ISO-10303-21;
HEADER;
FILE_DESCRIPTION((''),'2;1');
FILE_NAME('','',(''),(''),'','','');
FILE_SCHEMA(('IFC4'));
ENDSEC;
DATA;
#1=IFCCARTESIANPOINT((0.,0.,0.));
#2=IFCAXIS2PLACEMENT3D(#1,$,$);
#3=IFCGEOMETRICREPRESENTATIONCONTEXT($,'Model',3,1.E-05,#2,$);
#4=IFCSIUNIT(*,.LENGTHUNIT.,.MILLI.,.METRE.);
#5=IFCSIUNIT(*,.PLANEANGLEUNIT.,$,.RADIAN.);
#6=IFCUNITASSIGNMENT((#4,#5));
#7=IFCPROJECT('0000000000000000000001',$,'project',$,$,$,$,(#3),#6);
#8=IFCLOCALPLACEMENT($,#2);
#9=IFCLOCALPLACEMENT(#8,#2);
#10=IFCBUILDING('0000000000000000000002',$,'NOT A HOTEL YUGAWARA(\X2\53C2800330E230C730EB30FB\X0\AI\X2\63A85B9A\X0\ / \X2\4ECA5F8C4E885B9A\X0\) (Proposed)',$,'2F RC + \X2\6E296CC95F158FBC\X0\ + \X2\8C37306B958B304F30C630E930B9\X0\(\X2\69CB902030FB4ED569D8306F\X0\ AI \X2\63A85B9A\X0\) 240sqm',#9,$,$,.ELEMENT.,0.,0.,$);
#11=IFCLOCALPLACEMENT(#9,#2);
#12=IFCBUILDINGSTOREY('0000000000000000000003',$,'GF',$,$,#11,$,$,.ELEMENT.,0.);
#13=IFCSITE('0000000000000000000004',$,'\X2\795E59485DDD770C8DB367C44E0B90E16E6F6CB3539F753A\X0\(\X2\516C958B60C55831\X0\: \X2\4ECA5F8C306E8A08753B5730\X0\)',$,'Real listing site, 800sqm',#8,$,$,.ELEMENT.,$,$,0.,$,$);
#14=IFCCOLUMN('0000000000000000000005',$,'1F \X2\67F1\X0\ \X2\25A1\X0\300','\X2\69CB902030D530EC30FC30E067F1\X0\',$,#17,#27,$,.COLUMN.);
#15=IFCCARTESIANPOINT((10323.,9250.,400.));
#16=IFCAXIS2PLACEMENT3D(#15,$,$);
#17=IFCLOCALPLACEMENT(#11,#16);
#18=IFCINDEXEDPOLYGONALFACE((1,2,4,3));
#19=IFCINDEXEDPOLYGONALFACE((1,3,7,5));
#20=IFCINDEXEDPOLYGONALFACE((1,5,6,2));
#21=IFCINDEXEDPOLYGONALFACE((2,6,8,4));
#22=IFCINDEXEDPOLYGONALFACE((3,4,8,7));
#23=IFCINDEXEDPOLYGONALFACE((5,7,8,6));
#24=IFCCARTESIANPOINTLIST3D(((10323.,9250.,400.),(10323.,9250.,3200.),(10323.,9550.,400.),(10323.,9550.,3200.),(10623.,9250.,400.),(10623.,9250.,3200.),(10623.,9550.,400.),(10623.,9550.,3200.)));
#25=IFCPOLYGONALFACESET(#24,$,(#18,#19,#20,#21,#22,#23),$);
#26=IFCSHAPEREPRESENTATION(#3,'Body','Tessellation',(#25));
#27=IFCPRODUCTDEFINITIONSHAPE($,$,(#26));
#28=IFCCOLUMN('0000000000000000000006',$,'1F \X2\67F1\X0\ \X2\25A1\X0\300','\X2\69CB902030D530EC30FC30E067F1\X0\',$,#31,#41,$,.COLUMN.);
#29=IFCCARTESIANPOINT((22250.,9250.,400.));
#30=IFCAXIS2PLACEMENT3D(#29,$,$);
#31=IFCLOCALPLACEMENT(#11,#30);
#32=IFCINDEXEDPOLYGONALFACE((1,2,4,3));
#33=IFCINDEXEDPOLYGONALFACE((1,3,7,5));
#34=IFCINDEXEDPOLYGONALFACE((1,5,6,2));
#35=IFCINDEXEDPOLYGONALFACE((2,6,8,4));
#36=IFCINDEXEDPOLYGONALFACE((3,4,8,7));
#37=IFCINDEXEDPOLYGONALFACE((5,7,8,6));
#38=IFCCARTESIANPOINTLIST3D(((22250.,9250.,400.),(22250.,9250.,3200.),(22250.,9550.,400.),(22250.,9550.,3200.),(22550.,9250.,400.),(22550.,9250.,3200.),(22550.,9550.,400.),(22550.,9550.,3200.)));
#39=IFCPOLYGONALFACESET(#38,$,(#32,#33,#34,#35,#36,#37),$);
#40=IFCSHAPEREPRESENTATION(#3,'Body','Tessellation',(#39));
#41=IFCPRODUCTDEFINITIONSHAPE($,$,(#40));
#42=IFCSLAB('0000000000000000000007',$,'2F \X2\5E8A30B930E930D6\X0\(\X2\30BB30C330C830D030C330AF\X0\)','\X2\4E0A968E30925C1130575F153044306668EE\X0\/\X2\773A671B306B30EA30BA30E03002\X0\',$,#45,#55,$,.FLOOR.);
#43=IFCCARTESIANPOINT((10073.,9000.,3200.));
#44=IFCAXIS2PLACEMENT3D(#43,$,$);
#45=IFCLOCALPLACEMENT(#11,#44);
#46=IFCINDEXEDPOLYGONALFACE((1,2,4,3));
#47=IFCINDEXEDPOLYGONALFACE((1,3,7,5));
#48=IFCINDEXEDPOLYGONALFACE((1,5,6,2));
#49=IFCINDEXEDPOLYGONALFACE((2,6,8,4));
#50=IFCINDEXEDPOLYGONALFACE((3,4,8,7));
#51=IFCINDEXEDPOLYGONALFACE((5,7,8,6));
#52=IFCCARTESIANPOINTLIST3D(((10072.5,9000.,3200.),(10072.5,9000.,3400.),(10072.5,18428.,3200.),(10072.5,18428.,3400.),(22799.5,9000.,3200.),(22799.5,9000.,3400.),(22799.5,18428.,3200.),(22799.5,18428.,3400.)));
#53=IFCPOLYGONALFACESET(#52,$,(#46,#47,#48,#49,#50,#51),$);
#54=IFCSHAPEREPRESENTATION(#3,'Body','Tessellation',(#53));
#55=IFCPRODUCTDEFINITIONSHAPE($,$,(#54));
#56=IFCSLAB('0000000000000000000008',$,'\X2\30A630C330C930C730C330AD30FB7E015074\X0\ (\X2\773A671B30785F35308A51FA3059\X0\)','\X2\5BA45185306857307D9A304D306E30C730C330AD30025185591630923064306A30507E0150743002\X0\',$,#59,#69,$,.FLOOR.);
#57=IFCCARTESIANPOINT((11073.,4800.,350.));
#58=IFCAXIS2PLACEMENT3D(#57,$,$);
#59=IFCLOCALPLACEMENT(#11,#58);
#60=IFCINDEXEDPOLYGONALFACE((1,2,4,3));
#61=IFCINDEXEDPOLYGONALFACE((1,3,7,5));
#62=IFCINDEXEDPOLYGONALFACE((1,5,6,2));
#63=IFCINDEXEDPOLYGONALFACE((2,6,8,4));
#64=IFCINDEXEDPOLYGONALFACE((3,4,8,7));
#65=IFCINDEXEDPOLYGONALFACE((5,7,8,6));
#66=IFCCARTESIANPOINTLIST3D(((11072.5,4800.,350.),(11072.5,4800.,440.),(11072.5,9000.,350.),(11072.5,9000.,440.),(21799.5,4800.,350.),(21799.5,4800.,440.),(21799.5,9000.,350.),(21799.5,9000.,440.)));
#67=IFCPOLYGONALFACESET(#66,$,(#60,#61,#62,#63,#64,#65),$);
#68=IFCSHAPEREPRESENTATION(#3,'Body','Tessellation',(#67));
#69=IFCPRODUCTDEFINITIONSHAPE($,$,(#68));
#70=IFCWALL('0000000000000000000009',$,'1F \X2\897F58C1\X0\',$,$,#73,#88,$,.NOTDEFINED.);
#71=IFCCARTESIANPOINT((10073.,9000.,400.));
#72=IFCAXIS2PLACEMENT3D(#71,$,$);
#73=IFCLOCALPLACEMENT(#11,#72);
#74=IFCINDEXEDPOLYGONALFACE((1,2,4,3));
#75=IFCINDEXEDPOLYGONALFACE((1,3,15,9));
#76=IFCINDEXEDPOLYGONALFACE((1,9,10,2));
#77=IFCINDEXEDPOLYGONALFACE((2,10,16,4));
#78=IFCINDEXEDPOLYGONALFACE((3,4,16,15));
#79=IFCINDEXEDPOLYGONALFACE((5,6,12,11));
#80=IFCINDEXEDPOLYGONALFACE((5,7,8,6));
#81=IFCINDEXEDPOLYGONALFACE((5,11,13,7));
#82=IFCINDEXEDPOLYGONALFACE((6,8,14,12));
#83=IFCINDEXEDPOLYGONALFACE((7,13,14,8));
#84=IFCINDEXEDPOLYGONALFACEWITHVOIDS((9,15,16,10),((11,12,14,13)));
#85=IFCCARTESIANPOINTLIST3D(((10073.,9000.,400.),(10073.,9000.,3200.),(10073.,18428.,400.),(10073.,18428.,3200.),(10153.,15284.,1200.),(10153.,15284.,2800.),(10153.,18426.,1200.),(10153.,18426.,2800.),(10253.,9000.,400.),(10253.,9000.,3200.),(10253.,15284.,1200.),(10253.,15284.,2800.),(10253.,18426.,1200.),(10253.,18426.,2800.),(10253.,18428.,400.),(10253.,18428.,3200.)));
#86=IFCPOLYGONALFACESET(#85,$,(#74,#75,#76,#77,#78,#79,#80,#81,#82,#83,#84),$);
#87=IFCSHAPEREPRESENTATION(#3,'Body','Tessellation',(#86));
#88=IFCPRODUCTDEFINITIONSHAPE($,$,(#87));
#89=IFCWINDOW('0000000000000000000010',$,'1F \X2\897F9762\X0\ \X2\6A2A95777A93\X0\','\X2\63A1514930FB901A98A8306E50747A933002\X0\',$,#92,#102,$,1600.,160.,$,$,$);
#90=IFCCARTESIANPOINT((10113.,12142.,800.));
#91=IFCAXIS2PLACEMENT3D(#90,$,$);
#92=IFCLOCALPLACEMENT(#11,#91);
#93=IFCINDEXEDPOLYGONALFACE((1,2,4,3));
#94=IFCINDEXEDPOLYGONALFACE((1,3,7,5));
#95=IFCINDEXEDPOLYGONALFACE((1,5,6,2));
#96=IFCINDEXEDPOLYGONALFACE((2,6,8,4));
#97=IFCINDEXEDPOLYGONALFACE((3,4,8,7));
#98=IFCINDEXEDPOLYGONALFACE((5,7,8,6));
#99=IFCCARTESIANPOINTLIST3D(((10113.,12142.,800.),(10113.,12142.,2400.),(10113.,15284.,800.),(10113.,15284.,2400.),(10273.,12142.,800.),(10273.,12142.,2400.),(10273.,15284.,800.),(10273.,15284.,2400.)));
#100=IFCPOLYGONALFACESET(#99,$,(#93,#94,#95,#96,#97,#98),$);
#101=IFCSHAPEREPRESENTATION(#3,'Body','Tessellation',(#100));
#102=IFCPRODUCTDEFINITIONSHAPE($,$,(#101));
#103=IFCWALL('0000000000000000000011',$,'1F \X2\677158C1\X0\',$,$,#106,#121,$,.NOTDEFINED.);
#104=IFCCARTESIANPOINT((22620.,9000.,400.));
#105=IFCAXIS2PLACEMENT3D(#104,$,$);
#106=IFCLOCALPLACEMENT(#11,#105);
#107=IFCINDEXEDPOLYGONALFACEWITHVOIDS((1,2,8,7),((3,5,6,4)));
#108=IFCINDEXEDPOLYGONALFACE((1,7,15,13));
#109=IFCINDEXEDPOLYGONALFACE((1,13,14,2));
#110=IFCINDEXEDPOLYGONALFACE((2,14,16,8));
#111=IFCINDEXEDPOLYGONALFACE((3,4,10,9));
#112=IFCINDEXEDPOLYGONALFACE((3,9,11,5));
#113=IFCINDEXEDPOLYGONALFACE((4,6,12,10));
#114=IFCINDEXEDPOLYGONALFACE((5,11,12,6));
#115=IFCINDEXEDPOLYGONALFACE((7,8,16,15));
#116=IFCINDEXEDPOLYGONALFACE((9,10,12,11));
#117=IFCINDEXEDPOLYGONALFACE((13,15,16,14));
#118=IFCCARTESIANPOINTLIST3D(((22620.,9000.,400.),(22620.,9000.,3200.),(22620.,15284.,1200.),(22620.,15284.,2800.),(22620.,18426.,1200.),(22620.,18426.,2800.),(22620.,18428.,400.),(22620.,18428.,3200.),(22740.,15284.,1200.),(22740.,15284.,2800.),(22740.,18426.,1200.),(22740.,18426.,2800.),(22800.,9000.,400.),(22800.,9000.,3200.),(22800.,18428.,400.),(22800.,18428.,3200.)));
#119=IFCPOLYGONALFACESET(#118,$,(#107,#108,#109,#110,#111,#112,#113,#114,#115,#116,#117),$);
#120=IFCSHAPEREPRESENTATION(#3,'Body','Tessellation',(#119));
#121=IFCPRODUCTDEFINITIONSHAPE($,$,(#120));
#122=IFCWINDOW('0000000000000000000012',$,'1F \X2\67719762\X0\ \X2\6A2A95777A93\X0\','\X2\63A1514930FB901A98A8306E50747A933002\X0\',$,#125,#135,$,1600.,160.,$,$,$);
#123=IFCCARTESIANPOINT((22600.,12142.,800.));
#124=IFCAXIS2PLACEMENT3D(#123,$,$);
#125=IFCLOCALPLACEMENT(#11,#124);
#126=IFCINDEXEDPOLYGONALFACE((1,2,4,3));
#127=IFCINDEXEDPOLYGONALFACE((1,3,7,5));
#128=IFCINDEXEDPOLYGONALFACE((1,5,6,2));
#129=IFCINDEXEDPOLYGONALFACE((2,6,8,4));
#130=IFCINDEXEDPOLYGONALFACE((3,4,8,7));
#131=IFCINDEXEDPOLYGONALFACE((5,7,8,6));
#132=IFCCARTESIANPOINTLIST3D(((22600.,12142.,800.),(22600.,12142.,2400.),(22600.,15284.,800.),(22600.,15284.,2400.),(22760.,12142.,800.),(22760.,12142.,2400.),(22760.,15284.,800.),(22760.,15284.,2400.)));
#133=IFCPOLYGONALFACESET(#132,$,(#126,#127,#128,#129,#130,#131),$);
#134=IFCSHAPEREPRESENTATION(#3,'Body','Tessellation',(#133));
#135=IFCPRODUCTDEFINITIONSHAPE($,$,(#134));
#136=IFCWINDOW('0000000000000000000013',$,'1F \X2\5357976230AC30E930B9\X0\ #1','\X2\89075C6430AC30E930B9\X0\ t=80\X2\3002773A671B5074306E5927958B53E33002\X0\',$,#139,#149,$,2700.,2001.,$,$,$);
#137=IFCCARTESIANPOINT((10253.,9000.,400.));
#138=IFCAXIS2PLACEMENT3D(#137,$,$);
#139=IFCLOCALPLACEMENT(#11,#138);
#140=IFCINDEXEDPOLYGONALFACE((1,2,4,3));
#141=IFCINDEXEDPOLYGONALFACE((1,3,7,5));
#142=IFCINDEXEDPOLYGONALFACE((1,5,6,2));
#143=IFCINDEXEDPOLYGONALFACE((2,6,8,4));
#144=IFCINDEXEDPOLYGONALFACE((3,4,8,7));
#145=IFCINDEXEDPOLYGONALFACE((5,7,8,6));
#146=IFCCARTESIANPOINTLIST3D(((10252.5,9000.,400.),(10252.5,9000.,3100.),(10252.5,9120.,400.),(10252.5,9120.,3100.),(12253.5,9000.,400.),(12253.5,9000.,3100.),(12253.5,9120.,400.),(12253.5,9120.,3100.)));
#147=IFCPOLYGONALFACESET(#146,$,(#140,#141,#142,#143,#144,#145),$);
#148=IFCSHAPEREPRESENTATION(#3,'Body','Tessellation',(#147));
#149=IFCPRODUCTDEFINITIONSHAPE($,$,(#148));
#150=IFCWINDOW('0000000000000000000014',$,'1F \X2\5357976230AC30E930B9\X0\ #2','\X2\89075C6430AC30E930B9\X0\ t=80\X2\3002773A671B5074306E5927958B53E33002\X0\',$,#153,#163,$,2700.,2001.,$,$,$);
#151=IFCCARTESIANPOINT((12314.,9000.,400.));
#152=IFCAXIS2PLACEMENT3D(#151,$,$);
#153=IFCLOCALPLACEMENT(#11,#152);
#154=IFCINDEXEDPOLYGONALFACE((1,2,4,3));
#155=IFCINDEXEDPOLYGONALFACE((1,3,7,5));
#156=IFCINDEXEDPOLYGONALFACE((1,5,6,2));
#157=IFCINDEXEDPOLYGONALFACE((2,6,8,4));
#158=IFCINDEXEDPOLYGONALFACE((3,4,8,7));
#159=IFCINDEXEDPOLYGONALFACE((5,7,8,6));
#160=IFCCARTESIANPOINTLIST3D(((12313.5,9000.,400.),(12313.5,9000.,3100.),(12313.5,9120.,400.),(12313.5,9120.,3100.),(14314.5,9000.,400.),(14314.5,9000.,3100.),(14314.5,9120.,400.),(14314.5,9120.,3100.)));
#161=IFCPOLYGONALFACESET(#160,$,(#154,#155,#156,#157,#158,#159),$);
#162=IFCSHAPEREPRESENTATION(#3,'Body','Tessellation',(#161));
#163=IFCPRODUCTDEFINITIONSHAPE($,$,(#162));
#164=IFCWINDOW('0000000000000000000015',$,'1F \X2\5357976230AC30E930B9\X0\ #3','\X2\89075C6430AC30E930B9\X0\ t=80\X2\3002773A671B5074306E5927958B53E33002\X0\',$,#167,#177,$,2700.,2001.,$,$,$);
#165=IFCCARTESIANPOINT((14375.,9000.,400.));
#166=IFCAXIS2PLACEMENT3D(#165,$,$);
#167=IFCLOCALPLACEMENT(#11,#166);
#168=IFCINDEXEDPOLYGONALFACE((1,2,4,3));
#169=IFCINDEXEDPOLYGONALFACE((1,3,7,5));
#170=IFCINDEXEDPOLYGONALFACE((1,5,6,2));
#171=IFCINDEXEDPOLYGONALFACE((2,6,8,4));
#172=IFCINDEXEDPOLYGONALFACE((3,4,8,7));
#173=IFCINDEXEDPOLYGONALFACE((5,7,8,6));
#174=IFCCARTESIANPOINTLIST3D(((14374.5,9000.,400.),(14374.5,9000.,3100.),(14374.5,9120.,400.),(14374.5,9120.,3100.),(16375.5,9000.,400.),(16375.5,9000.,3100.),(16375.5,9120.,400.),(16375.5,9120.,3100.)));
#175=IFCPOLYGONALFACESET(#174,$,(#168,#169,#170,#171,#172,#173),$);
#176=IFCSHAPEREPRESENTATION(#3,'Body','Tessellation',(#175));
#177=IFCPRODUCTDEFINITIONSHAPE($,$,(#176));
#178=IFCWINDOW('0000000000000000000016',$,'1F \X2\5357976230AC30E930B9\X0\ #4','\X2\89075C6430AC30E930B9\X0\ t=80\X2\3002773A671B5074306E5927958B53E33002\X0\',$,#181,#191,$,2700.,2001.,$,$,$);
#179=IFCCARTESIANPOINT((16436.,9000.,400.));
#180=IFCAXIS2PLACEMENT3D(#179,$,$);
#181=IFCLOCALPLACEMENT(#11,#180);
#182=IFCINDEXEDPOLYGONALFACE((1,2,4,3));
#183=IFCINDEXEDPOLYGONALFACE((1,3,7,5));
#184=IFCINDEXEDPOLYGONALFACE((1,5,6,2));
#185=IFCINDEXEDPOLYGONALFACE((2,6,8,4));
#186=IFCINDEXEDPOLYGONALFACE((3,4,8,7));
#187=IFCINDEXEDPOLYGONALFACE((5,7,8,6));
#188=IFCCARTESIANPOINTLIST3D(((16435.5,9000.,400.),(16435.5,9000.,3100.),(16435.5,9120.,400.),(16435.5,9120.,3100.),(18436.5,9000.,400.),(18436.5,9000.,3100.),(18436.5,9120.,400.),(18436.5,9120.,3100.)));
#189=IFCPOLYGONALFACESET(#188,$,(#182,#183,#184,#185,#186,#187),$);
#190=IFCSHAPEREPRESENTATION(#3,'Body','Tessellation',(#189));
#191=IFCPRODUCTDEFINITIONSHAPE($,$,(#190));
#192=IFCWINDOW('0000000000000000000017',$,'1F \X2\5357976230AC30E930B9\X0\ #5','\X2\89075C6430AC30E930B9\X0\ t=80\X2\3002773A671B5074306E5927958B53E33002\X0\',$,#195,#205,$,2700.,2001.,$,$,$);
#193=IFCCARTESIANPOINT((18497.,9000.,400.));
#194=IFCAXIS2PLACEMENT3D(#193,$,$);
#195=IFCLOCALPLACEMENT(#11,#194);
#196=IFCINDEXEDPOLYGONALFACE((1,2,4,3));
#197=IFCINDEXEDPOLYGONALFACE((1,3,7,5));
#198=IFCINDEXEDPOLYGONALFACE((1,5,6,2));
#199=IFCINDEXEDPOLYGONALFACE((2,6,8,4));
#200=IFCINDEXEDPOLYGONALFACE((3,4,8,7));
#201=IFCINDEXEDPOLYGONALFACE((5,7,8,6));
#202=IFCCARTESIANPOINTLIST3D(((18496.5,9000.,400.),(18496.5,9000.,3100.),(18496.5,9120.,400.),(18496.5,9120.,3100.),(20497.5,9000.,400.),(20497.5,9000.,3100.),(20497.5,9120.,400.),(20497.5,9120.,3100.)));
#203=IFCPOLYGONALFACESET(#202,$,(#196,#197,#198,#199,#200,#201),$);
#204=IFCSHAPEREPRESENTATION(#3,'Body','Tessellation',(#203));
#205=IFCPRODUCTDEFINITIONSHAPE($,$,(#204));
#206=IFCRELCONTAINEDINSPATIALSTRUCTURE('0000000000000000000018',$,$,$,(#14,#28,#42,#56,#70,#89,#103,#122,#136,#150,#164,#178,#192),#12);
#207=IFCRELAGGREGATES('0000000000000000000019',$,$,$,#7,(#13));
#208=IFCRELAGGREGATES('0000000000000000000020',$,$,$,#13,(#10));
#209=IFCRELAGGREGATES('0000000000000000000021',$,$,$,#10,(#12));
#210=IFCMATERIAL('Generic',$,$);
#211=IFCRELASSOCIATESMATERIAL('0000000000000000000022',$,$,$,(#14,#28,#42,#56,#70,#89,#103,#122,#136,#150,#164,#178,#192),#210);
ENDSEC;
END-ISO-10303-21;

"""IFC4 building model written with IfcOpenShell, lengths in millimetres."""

from ifc_helpers import new_model, si_unit, frame, frame_2d, origin, place, context, project, spatial, rectangle, extrude, material, element, fill, save


model = new_model("IFC4")

# Units and contexts
model_context = context("Model", 3, precision=1e-05, world=origin())
ifc_project = project(units=[si_unit("LENGTHUNIT", "METRE", prefix="MILLI"), si_unit("PLANEANGLEUNIT", "RADIAN")], contexts=[model_context])

# Site, building, storey
site_placement = place(None, origin())
site = spatial("IfcSite", under=ifc_project, at=site_placement, Name="神奈川県足柄下郡湯河原町(公開情報: 今後の計画地)", ObjectType="Real listing site, 800sqm", CompositionType="ELEMENT", RefElevation=0.0)
building_placement = place(site_placement, origin())
building = spatial("IfcBuilding", under=site, at=building_placement, Name="NOT A HOTEL YUGAWARA(参考モデル・AI推定 / 今後予定) (Proposed)", ObjectType="2F RC + 温泉引込 + 谷に開くテラス(構造・仕様は AI 推定) 240sqm", CompositionType="ELEMENT", ElevationOfRefHeight=0.0, ElevationOfTerrain=0.0)
storey_placement = place(building_placement, origin())
storey = spatial("IfcBuildingStorey", under=building, at=storey_placement, Name="GF", CompositionType="ELEMENT", Elevation=0.0)

# Columns
ifc_material_1 = material(Name="Generic")
column_1_placement = place(storey_placement, frame((10323.0, 9250.0, 400.0)))
element("IfcColumn", 1, at=column_1_placement, inside=storey, material=ifc_material_1, Name="1F 柱 □300", Description="構造フレーム柱", PredefinedType="COLUMN", context=model_context, shape_type="SweptSolid", body=[
    extrude(rectangle(XDim=300.0, YDim=300.0, at=frame_2d((150.0, 150.0))), frame((10323.0, 9250.0, 400.0)), (0.0, 0.0, 1.0), 2800.0),
])
column_2_placement = place(storey_placement, frame((22250.0, 9250.0, 400.0)))
element("IfcColumn", 2, at=column_2_placement, inside=storey, material=ifc_material_1, Name="1F 柱 □300", Description="構造フレーム柱", PredefinedType="COLUMN", context=model_context, shape_type="SweptSolid", body=[
    extrude(rectangle(XDim=300.0, YDim=300.0, at=frame_2d((150.0, 150.0))), frame((22250.0, 9250.0, 400.0)), (0.0, 0.0, 1.0), 2800.0),
])

# Slabs
slab_1_placement = place(storey_placement, frame((10073.0, 9000.0, 3200.0)))
element("IfcSlab", 3, at=slab_1_placement, inside=storey, material=ifc_material_1, Name="2F 床スラブ(セットバック)", Description="上階を少し引いて森/眺望にリズム。", PredefinedType="FLOOR", context=model_context, shape_type="SweptSolid", body=[
    extrude(rectangle(XDim=12727.0, YDim=9428.0, at=frame_2d((6363.0, 4714.0))), frame((10073.0, 9000.0, 3200.0)), (0.0, 0.0, 1.0), 200.0),
])
slab_2_placement = place(storey_placement, frame((11073.0, 4800.0, 350.0)))
element("IfcSlab", 4, at=slab_2_placement, inside=storey, material=ifc_material_1, Name="ウッドデッキ・縁側 (眺望へ張り出す)", Description="室内と地続きのデッキ。内外をつなぐ縁側。", PredefinedType="FLOOR", context=model_context, shape_type="SweptSolid", body=[
    extrude(rectangle(XDim=10727.0, YDim=4200.0, at=frame_2d((5363.0, 2100.0))), frame((11073.0, 4800.0, 350.0)), (0.0, 0.0, 1.0), 90.0),
])

# Walls, openings, windows
wall_1_placement = place(storey_placement, frame((10073.0, 9000.0, 400.0)))
wall_1 = element("IfcWall", 5, at=wall_1_placement, inside=storey, material=ifc_material_1, Name="1F 西壁", PredefinedType="NOTDEFINED", context=model_context, shape_type="SweptSolid", body=[
    extrude(rectangle(XDim=180.0, YDim=9428.0, at=frame_2d((90.0, 4714.0))), frame((10073.0, 9000.0, 400.0)), (0.0, 0.0, 1.0), 2800.0),
])
opening_1_placement = place(storey_placement, frame((10113.0, 12142.0, 800.0)))
opening_1 = element("IfcOpeningElement", 6, at=opening_1_placement, cuts=wall_1, PredefinedType="NOTDEFINED", context=model_context, shape_type="SweptSolid", body=[
    extrude(rectangle(XDim=160.0, YDim=3142.0, at=frame_2d((80.0, 1571.0))), frame((10113.0, 12142.0, 800.0)), (0.0, 0.0, 1.0), 1600.0),
])
window_1_placement = place(storey_placement, frame((10113.0, 12142.0, 800.0)))
window_1 = element("IfcWindow", 7, at=window_1_placement, inside=storey, material=ifc_material_1, Name="1F 西面 横長窓", Description="採光・通風の側窓。", OverallHeight=1600.0, OverallWidth=160.0, context=model_context, shape_type="SweptSolid", body=[
    extrude(rectangle(XDim=160.0, YDim=3142.0, at=frame_2d((80.0, 1571.0))), frame((10113.0, 12142.0, 800.0)), (0.0, 0.0, 1.0), 1600.0),
])
fill(opening_1, window_1)
wall_2_placement = place(storey_placement, frame((22620.0, 9000.0, 400.0)))
wall_2 = element("IfcWall", 8, at=wall_2_placement, inside=storey, material=ifc_material_1, Name="1F 東壁", PredefinedType="NOTDEFINED", context=model_context, shape_type="SweptSolid", body=[
    extrude(rectangle(XDim=180.0, YDim=9428.0, at=frame_2d((90.0, 4714.0))), frame((22620.0, 9000.0, 400.0)), (0.0, 0.0, 1.0), 2800.0),
])
opening_2_placement = place(storey_placement, frame((22600.0, 12142.0, 800.0)))
opening_2 = element("IfcOpeningElement", 9, at=opening_2_placement, cuts=wall_2, PredefinedType="NOTDEFINED", context=model_context, shape_type="SweptSolid", body=[
    extrude(rectangle(XDim=160.0, YDim=3142.0, at=frame_2d((80.0, 1571.0))), frame((22600.0, 12142.0, 800.0)), (0.0, 0.0, 1.0), 1600.0),
])
window_2_placement = place(storey_placement, frame((22600.0, 12142.0, 800.0)))
window_2 = element("IfcWindow", 10, at=window_2_placement, inside=storey, material=ifc_material_1, Name="1F 東面 横長窓", Description="採光・通風の側窓。", OverallHeight=1600.0, OverallWidth=160.0, context=model_context, shape_type="SweptSolid", body=[
    extrude(rectangle(XDim=160.0, YDim=3142.0, at=frame_2d((80.0, 1571.0))), frame((22600.0, 12142.0, 800.0)), (0.0, 0.0, 1.0), 1600.0),
])
fill(opening_2, window_2)

# Windows
window_3_placement = place(storey_placement, frame((10253.0, 9000.0, 400.0)))
element("IfcWindow", 11, at=window_3_placement, inside=storey, material=ifc_material_1, Name="1F 南面ガラス #1", Description="複層ガラス t=80。眺望側の大開口。", OverallHeight=2700.0, OverallWidth=2001.0, context=model_context, shape_type="SweptSolid", body=[
    extrude(rectangle(XDim=2001.0, YDim=120.0, at=frame_2d((1000.0, 60.0))), frame((10253.0, 9000.0, 400.0)), (0.0, 0.0, 1.0), 2700.0),
])
window_4_placement = place(storey_placement, frame((12314.0, 9000.0, 400.0)))
element("IfcWindow", 12, at=window_4_placement, inside=storey, material=ifc_material_1, Name="1F 南面ガラス #2", Description="複層ガラス t=80。眺望側の大開口。", OverallHeight=2700.0, OverallWidth=2001.0, context=model_context, shape_type="SweptSolid", body=[
    extrude(rectangle(XDim=2001.0, YDim=120.0, at=frame_2d((1000.0, 60.0))), frame((12314.0, 9000.0, 400.0)), (0.0, 0.0, 1.0), 2700.0),
])
window_5_placement = place(storey_placement, frame((14375.0, 9000.0, 400.0)))
element("IfcWindow", 13, at=window_5_placement, inside=storey, material=ifc_material_1, Name="1F 南面ガラス #3", Description="複層ガラス t=80。眺望側の大開口。", OverallHeight=2700.0, OverallWidth=2001.0, context=model_context, shape_type="SweptSolid", body=[
    extrude(rectangle(XDim=2001.0, YDim=120.0, at=frame_2d((1000.0, 60.0))), frame((14375.0, 9000.0, 400.0)), (0.0, 0.0, 1.0), 2700.0),
])
window_6_placement = place(storey_placement, frame((16436.0, 9000.0, 400.0)))
element("IfcWindow", 14, at=window_6_placement, inside=storey, material=ifc_material_1, Name="1F 南面ガラス #4", Description="複層ガラス t=80。眺望側の大開口。", OverallHeight=2700.0, OverallWidth=2001.0, context=model_context, shape_type="SweptSolid", body=[
    extrude(rectangle(XDim=2001.0, YDim=120.0, at=frame_2d((1000.0, 60.0))), frame((16436.0, 9000.0, 400.0)), (0.0, 0.0, 1.0), 2700.0),
])
window_7_placement = place(storey_placement, frame((18497.0, 9000.0, 400.0)))
element("IfcWindow", 15, at=window_7_placement, inside=storey, material=ifc_material_1, Name="1F 南面ガラス #5", Description="複層ガラス t=80。眺望側の大開口。", OverallHeight=2700.0, OverallWidth=2001.0, context=model_context, shape_type="SweptSolid", body=[
    extrude(rectangle(XDim=2001.0, YDim=120.0, at=frame_2d((1000.0, 60.0))), frame((18497.0, 9000.0, 400.0)), (0.0, 0.0, 1.0), 2700.0),
])

save(model, "model.ifc")
